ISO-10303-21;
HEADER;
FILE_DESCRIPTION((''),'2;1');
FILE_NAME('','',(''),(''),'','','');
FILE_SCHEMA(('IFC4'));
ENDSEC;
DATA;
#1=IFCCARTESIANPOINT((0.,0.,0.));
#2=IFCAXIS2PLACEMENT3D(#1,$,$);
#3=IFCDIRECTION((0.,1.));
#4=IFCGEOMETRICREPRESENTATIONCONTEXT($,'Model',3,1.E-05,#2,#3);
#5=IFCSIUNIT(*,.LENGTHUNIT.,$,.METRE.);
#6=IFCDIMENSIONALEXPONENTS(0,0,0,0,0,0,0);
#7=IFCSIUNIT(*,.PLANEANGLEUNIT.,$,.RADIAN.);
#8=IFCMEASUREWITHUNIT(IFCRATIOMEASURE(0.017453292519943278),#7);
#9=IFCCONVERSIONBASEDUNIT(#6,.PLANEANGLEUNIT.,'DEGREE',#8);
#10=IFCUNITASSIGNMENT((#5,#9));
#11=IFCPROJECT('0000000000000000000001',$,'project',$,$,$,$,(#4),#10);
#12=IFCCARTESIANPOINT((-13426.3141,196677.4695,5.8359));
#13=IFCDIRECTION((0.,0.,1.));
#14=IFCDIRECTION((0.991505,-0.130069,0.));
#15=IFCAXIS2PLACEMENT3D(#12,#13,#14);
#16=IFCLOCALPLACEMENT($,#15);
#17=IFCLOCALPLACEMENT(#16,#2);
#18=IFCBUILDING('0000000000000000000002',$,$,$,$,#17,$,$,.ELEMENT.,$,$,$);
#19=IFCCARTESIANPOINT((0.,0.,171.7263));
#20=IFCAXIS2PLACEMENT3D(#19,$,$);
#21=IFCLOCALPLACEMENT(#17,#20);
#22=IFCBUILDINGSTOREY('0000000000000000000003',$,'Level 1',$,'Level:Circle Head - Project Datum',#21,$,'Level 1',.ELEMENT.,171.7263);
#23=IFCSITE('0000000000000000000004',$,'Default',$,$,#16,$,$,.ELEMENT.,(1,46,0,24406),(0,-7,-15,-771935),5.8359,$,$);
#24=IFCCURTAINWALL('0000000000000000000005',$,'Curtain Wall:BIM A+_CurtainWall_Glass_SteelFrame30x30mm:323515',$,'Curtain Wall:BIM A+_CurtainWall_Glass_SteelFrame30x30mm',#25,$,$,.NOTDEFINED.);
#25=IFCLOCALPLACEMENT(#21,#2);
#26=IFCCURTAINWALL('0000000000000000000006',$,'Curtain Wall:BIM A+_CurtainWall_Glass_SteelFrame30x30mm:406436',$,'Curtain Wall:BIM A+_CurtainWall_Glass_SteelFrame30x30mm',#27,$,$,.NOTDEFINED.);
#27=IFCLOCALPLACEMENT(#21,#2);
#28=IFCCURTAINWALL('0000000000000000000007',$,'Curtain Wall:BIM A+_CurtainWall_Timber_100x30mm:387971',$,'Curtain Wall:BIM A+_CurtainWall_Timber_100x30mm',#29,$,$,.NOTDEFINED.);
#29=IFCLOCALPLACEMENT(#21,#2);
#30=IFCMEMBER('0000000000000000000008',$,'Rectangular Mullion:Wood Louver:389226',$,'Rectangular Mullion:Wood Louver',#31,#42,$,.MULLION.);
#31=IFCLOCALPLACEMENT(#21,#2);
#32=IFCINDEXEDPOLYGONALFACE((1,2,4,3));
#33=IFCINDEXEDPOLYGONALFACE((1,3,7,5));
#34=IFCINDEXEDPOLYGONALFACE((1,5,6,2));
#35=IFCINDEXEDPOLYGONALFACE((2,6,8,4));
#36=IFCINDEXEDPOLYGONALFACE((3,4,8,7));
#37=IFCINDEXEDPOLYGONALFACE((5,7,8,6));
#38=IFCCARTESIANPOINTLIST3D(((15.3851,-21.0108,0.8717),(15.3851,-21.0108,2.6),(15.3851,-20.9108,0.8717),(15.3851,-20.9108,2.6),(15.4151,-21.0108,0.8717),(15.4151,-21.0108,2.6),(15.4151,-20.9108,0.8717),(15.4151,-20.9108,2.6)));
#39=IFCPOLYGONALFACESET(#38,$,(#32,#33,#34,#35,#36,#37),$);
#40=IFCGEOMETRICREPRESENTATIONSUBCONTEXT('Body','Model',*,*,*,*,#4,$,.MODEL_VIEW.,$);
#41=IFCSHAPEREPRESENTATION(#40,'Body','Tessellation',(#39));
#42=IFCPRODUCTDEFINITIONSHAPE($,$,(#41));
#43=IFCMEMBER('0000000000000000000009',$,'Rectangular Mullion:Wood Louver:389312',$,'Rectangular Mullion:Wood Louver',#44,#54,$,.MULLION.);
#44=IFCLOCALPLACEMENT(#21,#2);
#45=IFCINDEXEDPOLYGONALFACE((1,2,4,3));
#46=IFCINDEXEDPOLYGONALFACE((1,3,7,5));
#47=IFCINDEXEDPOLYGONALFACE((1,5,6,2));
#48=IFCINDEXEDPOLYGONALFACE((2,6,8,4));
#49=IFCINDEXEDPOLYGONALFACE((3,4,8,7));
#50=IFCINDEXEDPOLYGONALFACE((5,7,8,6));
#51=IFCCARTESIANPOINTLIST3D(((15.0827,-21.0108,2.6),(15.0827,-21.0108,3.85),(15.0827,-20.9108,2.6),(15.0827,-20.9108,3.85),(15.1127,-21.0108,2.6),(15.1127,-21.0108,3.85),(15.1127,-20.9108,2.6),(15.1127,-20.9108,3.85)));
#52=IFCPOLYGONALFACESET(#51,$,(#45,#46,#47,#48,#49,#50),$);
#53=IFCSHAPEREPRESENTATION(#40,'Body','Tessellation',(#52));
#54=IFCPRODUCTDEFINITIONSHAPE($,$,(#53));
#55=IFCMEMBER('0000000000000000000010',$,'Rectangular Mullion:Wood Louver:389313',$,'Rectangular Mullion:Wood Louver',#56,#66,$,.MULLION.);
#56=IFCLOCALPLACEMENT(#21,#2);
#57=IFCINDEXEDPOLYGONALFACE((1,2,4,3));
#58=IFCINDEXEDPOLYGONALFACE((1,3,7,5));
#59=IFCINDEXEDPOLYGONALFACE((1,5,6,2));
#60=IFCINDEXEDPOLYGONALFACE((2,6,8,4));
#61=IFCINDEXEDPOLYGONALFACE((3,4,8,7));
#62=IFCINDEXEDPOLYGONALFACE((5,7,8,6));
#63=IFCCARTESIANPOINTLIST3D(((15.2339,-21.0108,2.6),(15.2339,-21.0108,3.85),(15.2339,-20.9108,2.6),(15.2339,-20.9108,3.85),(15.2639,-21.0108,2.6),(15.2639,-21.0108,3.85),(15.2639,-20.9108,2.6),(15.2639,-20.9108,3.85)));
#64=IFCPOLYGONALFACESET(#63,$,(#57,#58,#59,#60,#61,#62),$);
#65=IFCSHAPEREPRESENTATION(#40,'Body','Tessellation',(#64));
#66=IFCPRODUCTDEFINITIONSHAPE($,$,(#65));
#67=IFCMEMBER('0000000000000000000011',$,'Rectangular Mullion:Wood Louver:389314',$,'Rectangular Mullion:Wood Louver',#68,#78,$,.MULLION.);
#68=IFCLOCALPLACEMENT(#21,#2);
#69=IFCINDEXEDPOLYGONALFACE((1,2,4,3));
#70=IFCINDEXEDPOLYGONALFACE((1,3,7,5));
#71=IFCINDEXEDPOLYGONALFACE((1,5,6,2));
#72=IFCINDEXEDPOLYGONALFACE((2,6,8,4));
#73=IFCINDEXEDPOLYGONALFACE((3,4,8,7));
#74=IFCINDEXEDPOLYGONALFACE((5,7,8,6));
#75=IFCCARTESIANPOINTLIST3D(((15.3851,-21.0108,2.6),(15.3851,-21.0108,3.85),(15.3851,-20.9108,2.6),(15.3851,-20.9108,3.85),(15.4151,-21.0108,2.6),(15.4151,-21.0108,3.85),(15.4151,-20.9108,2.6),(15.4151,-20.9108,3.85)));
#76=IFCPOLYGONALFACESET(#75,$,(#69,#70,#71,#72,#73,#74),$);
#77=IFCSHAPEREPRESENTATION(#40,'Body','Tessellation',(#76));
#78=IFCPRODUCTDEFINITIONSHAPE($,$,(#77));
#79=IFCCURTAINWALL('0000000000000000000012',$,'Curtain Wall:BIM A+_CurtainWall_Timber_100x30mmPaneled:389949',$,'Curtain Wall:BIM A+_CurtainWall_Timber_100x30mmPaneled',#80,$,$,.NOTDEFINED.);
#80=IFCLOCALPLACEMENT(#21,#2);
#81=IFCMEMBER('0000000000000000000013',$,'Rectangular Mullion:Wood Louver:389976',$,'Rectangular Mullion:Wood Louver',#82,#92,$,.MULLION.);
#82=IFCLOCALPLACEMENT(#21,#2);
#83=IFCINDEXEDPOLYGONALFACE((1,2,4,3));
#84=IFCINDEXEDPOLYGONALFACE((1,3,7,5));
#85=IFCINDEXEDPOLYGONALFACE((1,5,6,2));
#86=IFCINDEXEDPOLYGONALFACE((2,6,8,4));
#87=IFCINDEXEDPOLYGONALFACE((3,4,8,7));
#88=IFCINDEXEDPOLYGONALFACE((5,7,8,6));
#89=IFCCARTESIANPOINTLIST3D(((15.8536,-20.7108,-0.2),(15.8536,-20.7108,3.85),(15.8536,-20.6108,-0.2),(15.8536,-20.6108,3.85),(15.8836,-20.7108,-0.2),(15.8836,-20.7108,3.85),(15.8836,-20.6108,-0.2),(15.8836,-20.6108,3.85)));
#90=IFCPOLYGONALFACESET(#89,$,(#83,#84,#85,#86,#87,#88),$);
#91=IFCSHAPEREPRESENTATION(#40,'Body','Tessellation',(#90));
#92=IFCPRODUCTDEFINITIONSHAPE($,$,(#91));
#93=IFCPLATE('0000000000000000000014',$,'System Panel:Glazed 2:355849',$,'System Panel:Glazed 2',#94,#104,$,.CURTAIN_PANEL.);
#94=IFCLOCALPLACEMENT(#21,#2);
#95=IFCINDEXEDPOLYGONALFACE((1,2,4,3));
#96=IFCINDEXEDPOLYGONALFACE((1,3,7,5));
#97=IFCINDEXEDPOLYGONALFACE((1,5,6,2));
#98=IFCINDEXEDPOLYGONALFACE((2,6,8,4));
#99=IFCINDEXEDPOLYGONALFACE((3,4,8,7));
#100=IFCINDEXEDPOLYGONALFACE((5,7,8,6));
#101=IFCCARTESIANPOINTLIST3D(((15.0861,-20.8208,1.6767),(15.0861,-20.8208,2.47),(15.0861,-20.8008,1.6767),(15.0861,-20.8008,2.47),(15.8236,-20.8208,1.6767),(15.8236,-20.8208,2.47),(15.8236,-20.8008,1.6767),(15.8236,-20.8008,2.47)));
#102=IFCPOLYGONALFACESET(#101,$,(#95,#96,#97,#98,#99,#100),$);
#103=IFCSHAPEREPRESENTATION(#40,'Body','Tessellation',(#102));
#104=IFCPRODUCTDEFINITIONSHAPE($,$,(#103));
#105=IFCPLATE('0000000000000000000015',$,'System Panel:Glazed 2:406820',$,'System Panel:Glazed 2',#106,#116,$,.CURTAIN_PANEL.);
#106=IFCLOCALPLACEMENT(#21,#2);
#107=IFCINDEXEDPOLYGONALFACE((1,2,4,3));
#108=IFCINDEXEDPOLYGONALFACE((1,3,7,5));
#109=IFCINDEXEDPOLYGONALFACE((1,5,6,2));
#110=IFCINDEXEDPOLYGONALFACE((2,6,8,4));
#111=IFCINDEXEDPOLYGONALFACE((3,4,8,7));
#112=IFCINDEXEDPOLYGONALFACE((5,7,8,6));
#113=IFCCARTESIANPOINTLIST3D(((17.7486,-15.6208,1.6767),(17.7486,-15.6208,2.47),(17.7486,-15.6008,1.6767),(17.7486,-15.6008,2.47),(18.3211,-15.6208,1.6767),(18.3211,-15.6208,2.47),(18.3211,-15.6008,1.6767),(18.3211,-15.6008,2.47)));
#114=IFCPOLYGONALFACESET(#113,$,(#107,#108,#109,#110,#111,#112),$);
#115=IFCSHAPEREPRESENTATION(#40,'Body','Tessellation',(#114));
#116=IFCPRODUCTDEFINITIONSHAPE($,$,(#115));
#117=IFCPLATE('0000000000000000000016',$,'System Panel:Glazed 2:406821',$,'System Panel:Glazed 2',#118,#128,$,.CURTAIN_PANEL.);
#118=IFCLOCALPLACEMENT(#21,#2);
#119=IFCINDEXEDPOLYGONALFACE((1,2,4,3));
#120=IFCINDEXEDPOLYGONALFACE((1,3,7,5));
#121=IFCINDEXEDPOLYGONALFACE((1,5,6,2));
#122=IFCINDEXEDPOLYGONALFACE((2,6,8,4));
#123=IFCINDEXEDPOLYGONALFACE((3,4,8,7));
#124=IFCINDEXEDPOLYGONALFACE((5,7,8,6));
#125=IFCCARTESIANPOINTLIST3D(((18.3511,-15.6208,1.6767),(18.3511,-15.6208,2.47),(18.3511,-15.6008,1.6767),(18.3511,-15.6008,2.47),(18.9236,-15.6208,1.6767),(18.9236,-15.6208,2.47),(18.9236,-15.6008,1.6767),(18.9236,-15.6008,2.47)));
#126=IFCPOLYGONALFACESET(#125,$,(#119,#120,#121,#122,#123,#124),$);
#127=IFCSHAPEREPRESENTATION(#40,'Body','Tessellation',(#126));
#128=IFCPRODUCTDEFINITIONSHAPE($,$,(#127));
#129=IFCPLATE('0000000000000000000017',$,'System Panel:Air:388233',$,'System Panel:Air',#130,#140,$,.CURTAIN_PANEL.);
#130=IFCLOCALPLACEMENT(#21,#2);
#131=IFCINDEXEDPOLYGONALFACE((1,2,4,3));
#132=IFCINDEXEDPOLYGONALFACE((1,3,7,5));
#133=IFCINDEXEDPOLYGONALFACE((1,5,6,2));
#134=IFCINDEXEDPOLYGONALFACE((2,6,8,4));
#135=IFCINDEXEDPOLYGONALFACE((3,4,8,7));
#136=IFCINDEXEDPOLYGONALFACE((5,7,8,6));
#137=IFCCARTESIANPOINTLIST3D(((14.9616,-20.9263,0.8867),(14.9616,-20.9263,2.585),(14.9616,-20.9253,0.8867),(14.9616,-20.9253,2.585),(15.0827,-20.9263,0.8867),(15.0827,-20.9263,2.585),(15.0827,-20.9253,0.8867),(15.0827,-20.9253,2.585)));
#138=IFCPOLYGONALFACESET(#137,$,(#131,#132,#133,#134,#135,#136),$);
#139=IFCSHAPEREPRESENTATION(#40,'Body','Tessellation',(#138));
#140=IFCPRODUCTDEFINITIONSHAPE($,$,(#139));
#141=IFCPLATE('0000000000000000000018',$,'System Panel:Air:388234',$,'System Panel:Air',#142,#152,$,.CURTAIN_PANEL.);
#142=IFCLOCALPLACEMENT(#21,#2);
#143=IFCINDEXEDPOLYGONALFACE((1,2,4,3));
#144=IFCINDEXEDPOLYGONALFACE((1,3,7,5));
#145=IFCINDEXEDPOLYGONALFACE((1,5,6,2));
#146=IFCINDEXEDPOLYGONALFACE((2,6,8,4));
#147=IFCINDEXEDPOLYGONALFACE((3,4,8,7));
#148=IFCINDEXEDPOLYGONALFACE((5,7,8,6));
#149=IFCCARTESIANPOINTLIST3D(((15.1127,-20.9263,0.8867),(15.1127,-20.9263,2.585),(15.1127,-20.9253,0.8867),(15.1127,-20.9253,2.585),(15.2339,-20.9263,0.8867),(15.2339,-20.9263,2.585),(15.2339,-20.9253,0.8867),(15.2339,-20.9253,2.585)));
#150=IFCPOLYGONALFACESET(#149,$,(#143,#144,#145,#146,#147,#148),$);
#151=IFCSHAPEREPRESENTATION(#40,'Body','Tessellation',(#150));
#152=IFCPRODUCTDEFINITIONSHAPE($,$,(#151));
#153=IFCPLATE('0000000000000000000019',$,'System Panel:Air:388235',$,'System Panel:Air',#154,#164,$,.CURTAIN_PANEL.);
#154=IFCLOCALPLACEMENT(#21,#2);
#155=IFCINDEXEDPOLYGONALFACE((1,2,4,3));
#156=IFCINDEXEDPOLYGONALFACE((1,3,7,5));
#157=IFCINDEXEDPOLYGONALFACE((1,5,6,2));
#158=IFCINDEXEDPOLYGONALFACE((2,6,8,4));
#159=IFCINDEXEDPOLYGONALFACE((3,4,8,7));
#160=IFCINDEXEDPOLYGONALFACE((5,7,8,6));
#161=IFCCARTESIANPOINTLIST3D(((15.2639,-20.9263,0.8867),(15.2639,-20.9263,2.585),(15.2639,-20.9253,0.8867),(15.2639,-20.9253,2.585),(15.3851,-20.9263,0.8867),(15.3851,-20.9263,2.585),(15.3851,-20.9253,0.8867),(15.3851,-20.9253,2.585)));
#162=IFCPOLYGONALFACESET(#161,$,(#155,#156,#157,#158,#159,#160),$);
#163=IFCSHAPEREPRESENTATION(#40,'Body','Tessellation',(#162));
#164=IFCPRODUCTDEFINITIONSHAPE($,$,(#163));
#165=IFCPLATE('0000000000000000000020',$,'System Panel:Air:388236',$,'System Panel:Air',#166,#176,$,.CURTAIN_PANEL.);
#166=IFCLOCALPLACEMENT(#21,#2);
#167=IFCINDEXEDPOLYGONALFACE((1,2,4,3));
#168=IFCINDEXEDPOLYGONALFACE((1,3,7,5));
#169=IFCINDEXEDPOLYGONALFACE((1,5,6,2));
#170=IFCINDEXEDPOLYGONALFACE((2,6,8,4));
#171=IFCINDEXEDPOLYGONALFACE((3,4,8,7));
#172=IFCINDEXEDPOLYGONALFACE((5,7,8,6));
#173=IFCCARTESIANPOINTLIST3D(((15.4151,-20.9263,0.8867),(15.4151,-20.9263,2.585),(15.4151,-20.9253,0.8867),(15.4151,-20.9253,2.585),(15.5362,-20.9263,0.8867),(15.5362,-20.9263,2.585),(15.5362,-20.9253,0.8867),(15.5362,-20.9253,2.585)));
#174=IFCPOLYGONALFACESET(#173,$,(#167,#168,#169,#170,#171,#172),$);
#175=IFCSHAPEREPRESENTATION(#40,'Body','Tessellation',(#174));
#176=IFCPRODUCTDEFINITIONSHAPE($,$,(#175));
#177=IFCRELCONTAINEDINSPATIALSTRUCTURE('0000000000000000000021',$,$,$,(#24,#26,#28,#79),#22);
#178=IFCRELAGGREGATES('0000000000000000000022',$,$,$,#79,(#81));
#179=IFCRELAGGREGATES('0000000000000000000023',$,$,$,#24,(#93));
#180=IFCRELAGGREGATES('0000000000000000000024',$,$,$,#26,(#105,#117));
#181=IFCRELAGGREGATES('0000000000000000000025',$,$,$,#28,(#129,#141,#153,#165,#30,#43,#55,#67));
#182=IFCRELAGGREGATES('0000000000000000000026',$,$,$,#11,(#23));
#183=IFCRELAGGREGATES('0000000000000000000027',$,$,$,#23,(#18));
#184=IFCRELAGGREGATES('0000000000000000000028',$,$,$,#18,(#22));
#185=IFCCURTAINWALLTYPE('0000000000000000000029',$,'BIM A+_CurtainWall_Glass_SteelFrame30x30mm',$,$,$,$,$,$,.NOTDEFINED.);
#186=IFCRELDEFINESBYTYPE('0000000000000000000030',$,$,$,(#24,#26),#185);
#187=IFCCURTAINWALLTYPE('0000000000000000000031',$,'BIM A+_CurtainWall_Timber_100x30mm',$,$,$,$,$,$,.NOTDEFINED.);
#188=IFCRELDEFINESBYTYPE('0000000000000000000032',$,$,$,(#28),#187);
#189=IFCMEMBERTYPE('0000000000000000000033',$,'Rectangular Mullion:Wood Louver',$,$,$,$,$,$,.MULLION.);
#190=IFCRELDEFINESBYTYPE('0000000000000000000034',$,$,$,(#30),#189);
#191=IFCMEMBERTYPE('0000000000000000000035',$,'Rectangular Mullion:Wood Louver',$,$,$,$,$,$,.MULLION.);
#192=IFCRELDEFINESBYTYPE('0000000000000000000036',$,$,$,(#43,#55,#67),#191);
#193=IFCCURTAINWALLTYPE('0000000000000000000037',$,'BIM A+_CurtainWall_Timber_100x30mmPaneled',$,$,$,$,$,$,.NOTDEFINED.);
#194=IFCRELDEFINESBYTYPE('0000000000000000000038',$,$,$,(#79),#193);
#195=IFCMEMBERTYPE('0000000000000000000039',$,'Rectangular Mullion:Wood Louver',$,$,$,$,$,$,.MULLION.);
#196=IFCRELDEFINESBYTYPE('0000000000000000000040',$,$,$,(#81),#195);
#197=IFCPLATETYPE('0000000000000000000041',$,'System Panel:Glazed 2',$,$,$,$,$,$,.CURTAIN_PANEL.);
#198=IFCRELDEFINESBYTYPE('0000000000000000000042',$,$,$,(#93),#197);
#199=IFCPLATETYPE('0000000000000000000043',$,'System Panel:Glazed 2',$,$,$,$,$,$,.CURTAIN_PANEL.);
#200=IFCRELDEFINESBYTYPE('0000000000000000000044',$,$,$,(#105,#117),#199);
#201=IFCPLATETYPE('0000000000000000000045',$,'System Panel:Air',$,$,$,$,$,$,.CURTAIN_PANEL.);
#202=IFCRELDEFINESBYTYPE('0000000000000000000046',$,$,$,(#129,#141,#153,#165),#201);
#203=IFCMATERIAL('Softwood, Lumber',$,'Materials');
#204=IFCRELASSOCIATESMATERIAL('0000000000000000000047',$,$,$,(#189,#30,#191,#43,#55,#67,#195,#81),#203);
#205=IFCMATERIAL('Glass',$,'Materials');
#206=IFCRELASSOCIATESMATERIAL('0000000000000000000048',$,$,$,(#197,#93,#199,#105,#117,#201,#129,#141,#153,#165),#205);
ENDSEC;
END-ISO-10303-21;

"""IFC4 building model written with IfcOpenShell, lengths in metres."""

from ifc_helpers import new_model, entity, si_unit, converted_unit, direction, frame, origin, place, context, subcontext, project, spatial, indexed_curve, outline, extrude, source, transform, mapped, material, type_object, type_shapes, element, aggregate, save


model = new_model("IFC4")

# Units and contexts
model_context = context("Model", 3, precision=1e-05, world=origin(), true_north=direction((0.0, 1.0)))
body_context = subcontext(model_context, "Body", "Model", "MODEL_VIEW")
ifc_project = project(units=[si_unit("LENGTHUNIT", "METRE"), converted_unit("PLANEANGLEUNIT", "DEGREE", entity("IfcRatioMeasure", 0.017453292519943278), si_unit("PLANEANGLEUNIT", "RADIAN"), dimensions=[0, 0, 0, 0, 0, 0, 0])], contexts=[model_context])

# Site, building, storey
site_placement = place(None, frame((-13426.3141, 196677.4695, 5.8359), z_axis=(0.0, 0.0, 1.0), x_axis=(0.991505, -0.130069, 0.0)))
site = spatial("IfcSite", under=ifc_project, at=site_placement, Name="Default", CompositionType="ELEMENT", RefLatitude=(1, 46, 0, 24406), RefLongitude=(0, -7, -15, -771935), RefElevation=5.8359)
building_placement = place(site_placement, origin())
building = spatial("IfcBuilding", under=site, at=building_placement, CompositionType="ELEMENT")
storey_placement = place(building_placement, frame((0.0, 0.0, 171.7263)))
storey = spatial("IfcBuildingStorey", under=building, at=storey_placement, Name="Level 1", ObjectType="Level:Circle Head - Project Datum", LongName="Level 1", CompositionType="ELEMENT", Elevation=171.7263)

# Curtain wall
curtain_wall_type_1 = type_object("IfcCurtainWallType", Name="BIM A+_CurtainWall_Glass_SteelFrame30x30mm", PredefinedType="NOTDEFINED")
curtain_wall_1_placement = place(storey_placement, frame((0.0, 0.0, -171.7263)))
curtain_wall_1 = element("IfcCurtainWall", 1, at=curtain_wall_1_placement, inside=storey, type_object=curtain_wall_type_1, Name="Curtain Wall:BIM A+_CurtainWall_Glass_SteelFrame30x30mm:323515", ObjectType="Curtain Wall:BIM A+_CurtainWall_Glass_SteelFrame30x30mm", PredefinedType="NOTDEFINED")

# Curtain wall
curtain_wall_2_placement = place(storey_placement, frame((0.0, 0.0, -171.7263)))
curtain_wall_2 = element("IfcCurtainWall", 2, at=curtain_wall_2_placement, inside=storey, type_object=curtain_wall_type_1, Name="Curtain Wall:BIM A+_CurtainWall_Glass_SteelFrame30x30mm:406436", ObjectType="Curtain Wall:BIM A+_CurtainWall_Glass_SteelFrame30x30mm", PredefinedType="NOTDEFINED")

# Curtain wall, members
curtain_wall_type_2 = type_object("IfcCurtainWallType", Name="BIM A+_CurtainWall_Timber_100x30mm", PredefinedType="NOTDEFINED")
curtain_wall_3_placement = place(storey_placement, frame((0.0, 0.0, -171.7263)))
curtain_wall_3 = element("IfcCurtainWall", 3, at=curtain_wall_3_placement, inside=storey, type_object=curtain_wall_type_2, Name="Curtain Wall:BIM A+_CurtainWall_Timber_100x30mm:387971", ObjectType="Curtain Wall:BIM A+_CurtainWall_Timber_100x30mm", PredefinedType="NOTDEFINED")
ifc_material_1 = material(Name="Softwood, Lumber", Category="Materials")
member_type_1 = type_object("IfcMemberType", Name="Rectangular Mullion:Wood Louver", PredefinedType="MULLION", material=ifc_material_1)
shared_shape_1 = source(origin(), body_context, "Body", "SweptSolid", [
    extrude(outline(indexed_curve([(-0.05, -0.015), (0.05, -0.015), (0.05, 0.015), (-0.05, 0.015), (-0.05, -0.015)], self_intersect=False)), frame((0.0, 0.035, -1.7283), z_axis=(0.0, 0.0, 1.0), x_axis=(0.0, -1.0, 0.0)), (0.0, 0.0, 1.0), 1.7283),
])
type_shapes(member_type_1, [shared_shape_1])
member_1_placement = place(curtain_wall_3_placement, frame((15.4001, -20.9258, 172.598), z_axis=(0.0, 0.0, -1.0), x_axis=(1.0, 0.0, 0.0)))
member_1 = element("IfcMember", 4, at=member_1_placement, type_object=member_type_1, material=ifc_material_1, Name="Rectangular Mullion:Wood Louver:389226", ObjectType="Rectangular Mullion:Wood Louver", PredefinedType="MULLION", context=body_context, shape_type="MappedRepresentation", body=[
    mapped(shared_shape_1, transform((0.0, 0.0, 0.0), scale=1.0)),
])
member_type_2 = type_object("IfcMemberType", Name="Rectangular Mullion:Wood Louver", PredefinedType="MULLION", material=ifc_material_1)
shared_shape_2 = source(origin(), body_context, "Body", "SweptSolid", [
    extrude(outline(indexed_curve([(-0.05, -0.015), (0.05, -0.015), (0.05, 0.015), (-0.05, 0.015), (-0.05, -0.015)], self_intersect=False)), frame((0.0, 0.035, -1.25), z_axis=(0.0, 0.0, 1.0), x_axis=(0.0, -1.0, 0.0)), (0.0, 0.0, 1.0), 1.25),
])
type_shapes(member_type_2, [shared_shape_2])
member_2_placement = place(curtain_wall_3_placement, frame((15.0977, -20.9258, 174.3263), z_axis=(0.0, 0.0, -1.0), x_axis=(1.0, 0.0, 0.0)))
member_2 = element("IfcMember", 5, at=member_2_placement, type_object=member_type_2, material=ifc_material_1, Name="Rectangular Mullion:Wood Louver:389312", ObjectType="Rectangular Mullion:Wood Louver", PredefinedType="MULLION", context=body_context, shape_type="MappedRepresentation", body=[
    mapped(shared_shape_2, transform((0.0, 0.0, 0.0), scale=1.0)),
])
member_3_placement = place(curtain_wall_3_placement, frame((15.2489, -20.9258, 174.3263), z_axis=(0.0, 0.0, -1.0), x_axis=(1.0, 0.0, 0.0)))
member_3 = element("IfcMember", 6, at=member_3_placement, type_object=member_type_2, material=ifc_material_1, Name="Rectangular Mullion:Wood Louver:389313", ObjectType="Rectangular Mullion:Wood Louver", PredefinedType="MULLION", context=body_context, shape_type="MappedRepresentation", body=[
    mapped(shared_shape_2, transform((0.0, 0.0, 0.0), scale=1.0)),
])
member_4_placement = place(curtain_wall_3_placement, frame((15.4001, -20.9258, 174.3263), z_axis=(0.0, 0.0, -1.0), x_axis=(1.0, 0.0, 0.0)))
member_4 = element("IfcMember", 7, at=member_4_placement, type_object=member_type_2, material=ifc_material_1, Name="Rectangular Mullion:Wood Louver:389314", ObjectType="Rectangular Mullion:Wood Louver", PredefinedType="MULLION", context=body_context, shape_type="MappedRepresentation", body=[
    mapped(shared_shape_2, transform((0.0, 0.0, 0.0), scale=1.0)),
])

# Curtain wall, member
curtain_wall_type_3 = type_object("IfcCurtainWallType", Name="BIM A+_CurtainWall_Timber_100x30mmPaneled", PredefinedType="NOTDEFINED")
curtain_wall_4_placement = place(storey_placement, frame((0.0, 0.0, -171.7263)))
curtain_wall_4 = element("IfcCurtainWall", 8, at=curtain_wall_4_placement, inside=storey, type_object=curtain_wall_type_3, Name="Curtain Wall:BIM A+_CurtainWall_Timber_100x30mmPaneled:389949", ObjectType="Curtain Wall:BIM A+_CurtainWall_Timber_100x30mmPaneled", PredefinedType="NOTDEFINED")
member_type_3 = type_object("IfcMemberType", Name="Rectangular Mullion:Wood Louver", PredefinedType="MULLION", material=ifc_material_1)
shared_shape_3 = source(origin(), body_context, "Body", "SweptSolid", [
    extrude(outline(indexed_curve([(-0.05, -0.015), (0.05, -0.015), (0.05, 0.015), (-0.05, 0.015), (-0.05, -0.015)], self_intersect=False)), frame((-0.015, -0.035, -4.05), z_axis=(0.0, 0.0, 1.0), x_axis=(0.0, -1.0, 0.0)), (0.0, 0.0, 1.0), 4.05),
])
type_shapes(member_type_3, [shared_shape_3])
member_5_placement = place(curtain_wall_4_placement, frame((15.8536, -20.6958, 175.5763), z_axis=(0.0, 0.0, 1.0), x_axis=(-1.0, 0.0, 0.0)))
member_5 = element("IfcMember", 9, at=member_5_placement, type_object=member_type_3, material=ifc_material_1, Name="Rectangular Mullion:Wood Louver:389976", ObjectType="Rectangular Mullion:Wood Louver", PredefinedType="MULLION", context=body_context, shape_type="MappedRepresentation", body=[
    mapped(shared_shape_3, transform((0.0, 0.0, 0.0), scale=1.0)),
])
aggregate(curtain_wall_4, [member_5])

# Plates
ifc_material_2 = material(Name="Glass", Category="Materials")
plate_type_1 = type_object("IfcPlateType", Name="System Panel:Glazed 2", PredefinedType="CURTAIN_PANEL", material=ifc_material_2)
shared_shape_4 = source(origin(), body_context, "Body", "SweptSolid", [
    extrude(outline(indexed_curve([(-0.01, -0.3688), (0.01, -0.3688), (0.01, 0.3688), (-0.01, 0.3688), (-0.01, -0.3688)], self_intersect=False)), frame((0.0, 0.0, 0.0), z_axis=(0.0, 0.0, 1.0), x_axis=(0.0, 1.0, 0.0)), (0.0, 0.0, 1.0), 0.7933),
])
type_shapes(plate_type_1, [shared_shape_4])
plate_1_placement = place(curtain_wall_1_placement, frame((15.4548, -20.8108, 173.4029)))
plate_1 = element("IfcPlate", 10, at=plate_1_placement, type_object=plate_type_1, material=ifc_material_2, Name="System Panel:Glazed 2:355849", ObjectType="System Panel:Glazed 2", PredefinedType="CURTAIN_PANEL", context=body_context, shape_type="MappedRepresentation", body=[
    mapped(shared_shape_4, transform((0.0, 0.0, 0.0), scale=1.0)),
])
aggregate(curtain_wall_1, [plate_1])
plate_type_2 = type_object("IfcPlateType", Name="System Panel:Glazed 2", PredefinedType="CURTAIN_PANEL", material=ifc_material_2)
shared_shape_5 = source(origin(), body_context, "Body", "SweptSolid", [
    extrude(outline(indexed_curve([(-0.01, -0.2863), (0.01, -0.2863), (0.01, 0.2863), (-0.01, 0.2863), (-0.01, -0.2863)], self_intersect=False)), frame((0.0, 0.0, 0.0), z_axis=(0.0, 0.0, 1.0), x_axis=(0.0, 1.0, 0.0)), (0.0, 0.0, 1.0), 0.7933),
])
type_shapes(plate_type_2, [shared_shape_5])
plate_2_placement = place(curtain_wall_2_placement, frame((18.0348, -15.6108, 173.4029)))
plate_2 = element("IfcPlate", 11, at=plate_2_placement, type_object=plate_type_2, material=ifc_material_2, Name="System Panel:Glazed 2:406820", ObjectType="System Panel:Glazed 2", PredefinedType="CURTAIN_PANEL", context=body_context, shape_type="MappedRepresentation", body=[
    mapped(shared_shape_5, transform((0.0, 0.0, 0.0), scale=1.0)),
])
plate_3_placement = place(curtain_wall_2_placement, frame((18.6373, -15.6108, 173.4029)))
plate_3 = element("IfcPlate", 12, at=plate_3_placement, type_object=plate_type_2, material=ifc_material_2, Name="System Panel:Glazed 2:406821", ObjectType="System Panel:Glazed 2", PredefinedType="CURTAIN_PANEL", context=body_context, shape_type="MappedRepresentation", body=[
    mapped(shared_shape_5, transform((0.0, 0.0, 0.0), scale=1.0)),
])
aggregate(curtain_wall_2, [plate_2, plate_3])
plate_type_3 = type_object("IfcPlateType", Name="System Panel:Air", PredefinedType="CURTAIN_PANEL", material=ifc_material_2)
shared_shape_6 = source(origin(), body_context, "Body", "SweptSolid", [
    extrude(outline(indexed_curve([(-0.0005, -0.0606), (0.0005, -0.0606), (0.0005, 0.0606), (-0.0005, 0.0606), (-0.0005, -0.0606)], self_intersect=False)), frame((0.0, 0.0, 0.0), z_axis=(0.0, 0.0, 1.0), x_axis=(0.0, 1.0, 0.0)), (0.0, 0.0, 1.0), 1.6983),
])
type_shapes(plate_type_3, [shared_shape_6])
plate_4_placement = place(curtain_wall_3_placement, frame((15.0222, -20.9258, 172.613)))
plate_4 = element("IfcPlate", 13, at=plate_4_placement, type_object=plate_type_3, material=ifc_material_2, Name="System Panel:Air:388233", ObjectType="System Panel:Air", PredefinedType="CURTAIN_PANEL", context=body_context, shape_type="MappedRepresentation", body=[
    mapped(shared_shape_6, transform((0.0, 0.0, 0.0), scale=1.0)),
])
plate_5_placement = place(curtain_wall_3_placement, frame((15.1733, -20.9258, 172.613)))
plate_5 = element("IfcPlate", 14, at=plate_5_placement, type_object=plate_type_3, material=ifc_material_2, Name="System Panel:Air:388234", ObjectType="System Panel:Air", PredefinedType="CURTAIN_PANEL", context=body_context, shape_type="MappedRepresentation", body=[
    mapped(shared_shape_6, transform((0.0, 0.0, 0.0), scale=1.0)),
])
plate_6_placement = place(curtain_wall_3_placement, frame((15.3245, -20.9258, 172.613)))
plate_6 = element("IfcPlate", 15, at=plate_6_placement, type_object=plate_type_3, material=ifc_material_2, Name="System Panel:Air:388235", ObjectType="System Panel:Air", PredefinedType="CURTAIN_PANEL", context=body_context, shape_type="MappedRepresentation", body=[
    mapped(shared_shape_6, transform((0.0, 0.0, 0.0), scale=1.0)),
])
plate_7_placement = place(curtain_wall_3_placement, frame((15.4757, -20.9258, 172.613)))
plate_7 = element("IfcPlate", 16, at=plate_7_placement, type_object=plate_type_3, material=ifc_material_2, Name="System Panel:Air:388236", ObjectType="System Panel:Air", PredefinedType="CURTAIN_PANEL", context=body_context, shape_type="MappedRepresentation", body=[
    mapped(shared_shape_6, transform((0.0, 0.0, 0.0), scale=1.0)),
])
aggregate(curtain_wall_3, [plate_4, plate_5, plate_6, plate_7, member_1, member_2, member_3, member_4])

save(model, "model.ifc")
